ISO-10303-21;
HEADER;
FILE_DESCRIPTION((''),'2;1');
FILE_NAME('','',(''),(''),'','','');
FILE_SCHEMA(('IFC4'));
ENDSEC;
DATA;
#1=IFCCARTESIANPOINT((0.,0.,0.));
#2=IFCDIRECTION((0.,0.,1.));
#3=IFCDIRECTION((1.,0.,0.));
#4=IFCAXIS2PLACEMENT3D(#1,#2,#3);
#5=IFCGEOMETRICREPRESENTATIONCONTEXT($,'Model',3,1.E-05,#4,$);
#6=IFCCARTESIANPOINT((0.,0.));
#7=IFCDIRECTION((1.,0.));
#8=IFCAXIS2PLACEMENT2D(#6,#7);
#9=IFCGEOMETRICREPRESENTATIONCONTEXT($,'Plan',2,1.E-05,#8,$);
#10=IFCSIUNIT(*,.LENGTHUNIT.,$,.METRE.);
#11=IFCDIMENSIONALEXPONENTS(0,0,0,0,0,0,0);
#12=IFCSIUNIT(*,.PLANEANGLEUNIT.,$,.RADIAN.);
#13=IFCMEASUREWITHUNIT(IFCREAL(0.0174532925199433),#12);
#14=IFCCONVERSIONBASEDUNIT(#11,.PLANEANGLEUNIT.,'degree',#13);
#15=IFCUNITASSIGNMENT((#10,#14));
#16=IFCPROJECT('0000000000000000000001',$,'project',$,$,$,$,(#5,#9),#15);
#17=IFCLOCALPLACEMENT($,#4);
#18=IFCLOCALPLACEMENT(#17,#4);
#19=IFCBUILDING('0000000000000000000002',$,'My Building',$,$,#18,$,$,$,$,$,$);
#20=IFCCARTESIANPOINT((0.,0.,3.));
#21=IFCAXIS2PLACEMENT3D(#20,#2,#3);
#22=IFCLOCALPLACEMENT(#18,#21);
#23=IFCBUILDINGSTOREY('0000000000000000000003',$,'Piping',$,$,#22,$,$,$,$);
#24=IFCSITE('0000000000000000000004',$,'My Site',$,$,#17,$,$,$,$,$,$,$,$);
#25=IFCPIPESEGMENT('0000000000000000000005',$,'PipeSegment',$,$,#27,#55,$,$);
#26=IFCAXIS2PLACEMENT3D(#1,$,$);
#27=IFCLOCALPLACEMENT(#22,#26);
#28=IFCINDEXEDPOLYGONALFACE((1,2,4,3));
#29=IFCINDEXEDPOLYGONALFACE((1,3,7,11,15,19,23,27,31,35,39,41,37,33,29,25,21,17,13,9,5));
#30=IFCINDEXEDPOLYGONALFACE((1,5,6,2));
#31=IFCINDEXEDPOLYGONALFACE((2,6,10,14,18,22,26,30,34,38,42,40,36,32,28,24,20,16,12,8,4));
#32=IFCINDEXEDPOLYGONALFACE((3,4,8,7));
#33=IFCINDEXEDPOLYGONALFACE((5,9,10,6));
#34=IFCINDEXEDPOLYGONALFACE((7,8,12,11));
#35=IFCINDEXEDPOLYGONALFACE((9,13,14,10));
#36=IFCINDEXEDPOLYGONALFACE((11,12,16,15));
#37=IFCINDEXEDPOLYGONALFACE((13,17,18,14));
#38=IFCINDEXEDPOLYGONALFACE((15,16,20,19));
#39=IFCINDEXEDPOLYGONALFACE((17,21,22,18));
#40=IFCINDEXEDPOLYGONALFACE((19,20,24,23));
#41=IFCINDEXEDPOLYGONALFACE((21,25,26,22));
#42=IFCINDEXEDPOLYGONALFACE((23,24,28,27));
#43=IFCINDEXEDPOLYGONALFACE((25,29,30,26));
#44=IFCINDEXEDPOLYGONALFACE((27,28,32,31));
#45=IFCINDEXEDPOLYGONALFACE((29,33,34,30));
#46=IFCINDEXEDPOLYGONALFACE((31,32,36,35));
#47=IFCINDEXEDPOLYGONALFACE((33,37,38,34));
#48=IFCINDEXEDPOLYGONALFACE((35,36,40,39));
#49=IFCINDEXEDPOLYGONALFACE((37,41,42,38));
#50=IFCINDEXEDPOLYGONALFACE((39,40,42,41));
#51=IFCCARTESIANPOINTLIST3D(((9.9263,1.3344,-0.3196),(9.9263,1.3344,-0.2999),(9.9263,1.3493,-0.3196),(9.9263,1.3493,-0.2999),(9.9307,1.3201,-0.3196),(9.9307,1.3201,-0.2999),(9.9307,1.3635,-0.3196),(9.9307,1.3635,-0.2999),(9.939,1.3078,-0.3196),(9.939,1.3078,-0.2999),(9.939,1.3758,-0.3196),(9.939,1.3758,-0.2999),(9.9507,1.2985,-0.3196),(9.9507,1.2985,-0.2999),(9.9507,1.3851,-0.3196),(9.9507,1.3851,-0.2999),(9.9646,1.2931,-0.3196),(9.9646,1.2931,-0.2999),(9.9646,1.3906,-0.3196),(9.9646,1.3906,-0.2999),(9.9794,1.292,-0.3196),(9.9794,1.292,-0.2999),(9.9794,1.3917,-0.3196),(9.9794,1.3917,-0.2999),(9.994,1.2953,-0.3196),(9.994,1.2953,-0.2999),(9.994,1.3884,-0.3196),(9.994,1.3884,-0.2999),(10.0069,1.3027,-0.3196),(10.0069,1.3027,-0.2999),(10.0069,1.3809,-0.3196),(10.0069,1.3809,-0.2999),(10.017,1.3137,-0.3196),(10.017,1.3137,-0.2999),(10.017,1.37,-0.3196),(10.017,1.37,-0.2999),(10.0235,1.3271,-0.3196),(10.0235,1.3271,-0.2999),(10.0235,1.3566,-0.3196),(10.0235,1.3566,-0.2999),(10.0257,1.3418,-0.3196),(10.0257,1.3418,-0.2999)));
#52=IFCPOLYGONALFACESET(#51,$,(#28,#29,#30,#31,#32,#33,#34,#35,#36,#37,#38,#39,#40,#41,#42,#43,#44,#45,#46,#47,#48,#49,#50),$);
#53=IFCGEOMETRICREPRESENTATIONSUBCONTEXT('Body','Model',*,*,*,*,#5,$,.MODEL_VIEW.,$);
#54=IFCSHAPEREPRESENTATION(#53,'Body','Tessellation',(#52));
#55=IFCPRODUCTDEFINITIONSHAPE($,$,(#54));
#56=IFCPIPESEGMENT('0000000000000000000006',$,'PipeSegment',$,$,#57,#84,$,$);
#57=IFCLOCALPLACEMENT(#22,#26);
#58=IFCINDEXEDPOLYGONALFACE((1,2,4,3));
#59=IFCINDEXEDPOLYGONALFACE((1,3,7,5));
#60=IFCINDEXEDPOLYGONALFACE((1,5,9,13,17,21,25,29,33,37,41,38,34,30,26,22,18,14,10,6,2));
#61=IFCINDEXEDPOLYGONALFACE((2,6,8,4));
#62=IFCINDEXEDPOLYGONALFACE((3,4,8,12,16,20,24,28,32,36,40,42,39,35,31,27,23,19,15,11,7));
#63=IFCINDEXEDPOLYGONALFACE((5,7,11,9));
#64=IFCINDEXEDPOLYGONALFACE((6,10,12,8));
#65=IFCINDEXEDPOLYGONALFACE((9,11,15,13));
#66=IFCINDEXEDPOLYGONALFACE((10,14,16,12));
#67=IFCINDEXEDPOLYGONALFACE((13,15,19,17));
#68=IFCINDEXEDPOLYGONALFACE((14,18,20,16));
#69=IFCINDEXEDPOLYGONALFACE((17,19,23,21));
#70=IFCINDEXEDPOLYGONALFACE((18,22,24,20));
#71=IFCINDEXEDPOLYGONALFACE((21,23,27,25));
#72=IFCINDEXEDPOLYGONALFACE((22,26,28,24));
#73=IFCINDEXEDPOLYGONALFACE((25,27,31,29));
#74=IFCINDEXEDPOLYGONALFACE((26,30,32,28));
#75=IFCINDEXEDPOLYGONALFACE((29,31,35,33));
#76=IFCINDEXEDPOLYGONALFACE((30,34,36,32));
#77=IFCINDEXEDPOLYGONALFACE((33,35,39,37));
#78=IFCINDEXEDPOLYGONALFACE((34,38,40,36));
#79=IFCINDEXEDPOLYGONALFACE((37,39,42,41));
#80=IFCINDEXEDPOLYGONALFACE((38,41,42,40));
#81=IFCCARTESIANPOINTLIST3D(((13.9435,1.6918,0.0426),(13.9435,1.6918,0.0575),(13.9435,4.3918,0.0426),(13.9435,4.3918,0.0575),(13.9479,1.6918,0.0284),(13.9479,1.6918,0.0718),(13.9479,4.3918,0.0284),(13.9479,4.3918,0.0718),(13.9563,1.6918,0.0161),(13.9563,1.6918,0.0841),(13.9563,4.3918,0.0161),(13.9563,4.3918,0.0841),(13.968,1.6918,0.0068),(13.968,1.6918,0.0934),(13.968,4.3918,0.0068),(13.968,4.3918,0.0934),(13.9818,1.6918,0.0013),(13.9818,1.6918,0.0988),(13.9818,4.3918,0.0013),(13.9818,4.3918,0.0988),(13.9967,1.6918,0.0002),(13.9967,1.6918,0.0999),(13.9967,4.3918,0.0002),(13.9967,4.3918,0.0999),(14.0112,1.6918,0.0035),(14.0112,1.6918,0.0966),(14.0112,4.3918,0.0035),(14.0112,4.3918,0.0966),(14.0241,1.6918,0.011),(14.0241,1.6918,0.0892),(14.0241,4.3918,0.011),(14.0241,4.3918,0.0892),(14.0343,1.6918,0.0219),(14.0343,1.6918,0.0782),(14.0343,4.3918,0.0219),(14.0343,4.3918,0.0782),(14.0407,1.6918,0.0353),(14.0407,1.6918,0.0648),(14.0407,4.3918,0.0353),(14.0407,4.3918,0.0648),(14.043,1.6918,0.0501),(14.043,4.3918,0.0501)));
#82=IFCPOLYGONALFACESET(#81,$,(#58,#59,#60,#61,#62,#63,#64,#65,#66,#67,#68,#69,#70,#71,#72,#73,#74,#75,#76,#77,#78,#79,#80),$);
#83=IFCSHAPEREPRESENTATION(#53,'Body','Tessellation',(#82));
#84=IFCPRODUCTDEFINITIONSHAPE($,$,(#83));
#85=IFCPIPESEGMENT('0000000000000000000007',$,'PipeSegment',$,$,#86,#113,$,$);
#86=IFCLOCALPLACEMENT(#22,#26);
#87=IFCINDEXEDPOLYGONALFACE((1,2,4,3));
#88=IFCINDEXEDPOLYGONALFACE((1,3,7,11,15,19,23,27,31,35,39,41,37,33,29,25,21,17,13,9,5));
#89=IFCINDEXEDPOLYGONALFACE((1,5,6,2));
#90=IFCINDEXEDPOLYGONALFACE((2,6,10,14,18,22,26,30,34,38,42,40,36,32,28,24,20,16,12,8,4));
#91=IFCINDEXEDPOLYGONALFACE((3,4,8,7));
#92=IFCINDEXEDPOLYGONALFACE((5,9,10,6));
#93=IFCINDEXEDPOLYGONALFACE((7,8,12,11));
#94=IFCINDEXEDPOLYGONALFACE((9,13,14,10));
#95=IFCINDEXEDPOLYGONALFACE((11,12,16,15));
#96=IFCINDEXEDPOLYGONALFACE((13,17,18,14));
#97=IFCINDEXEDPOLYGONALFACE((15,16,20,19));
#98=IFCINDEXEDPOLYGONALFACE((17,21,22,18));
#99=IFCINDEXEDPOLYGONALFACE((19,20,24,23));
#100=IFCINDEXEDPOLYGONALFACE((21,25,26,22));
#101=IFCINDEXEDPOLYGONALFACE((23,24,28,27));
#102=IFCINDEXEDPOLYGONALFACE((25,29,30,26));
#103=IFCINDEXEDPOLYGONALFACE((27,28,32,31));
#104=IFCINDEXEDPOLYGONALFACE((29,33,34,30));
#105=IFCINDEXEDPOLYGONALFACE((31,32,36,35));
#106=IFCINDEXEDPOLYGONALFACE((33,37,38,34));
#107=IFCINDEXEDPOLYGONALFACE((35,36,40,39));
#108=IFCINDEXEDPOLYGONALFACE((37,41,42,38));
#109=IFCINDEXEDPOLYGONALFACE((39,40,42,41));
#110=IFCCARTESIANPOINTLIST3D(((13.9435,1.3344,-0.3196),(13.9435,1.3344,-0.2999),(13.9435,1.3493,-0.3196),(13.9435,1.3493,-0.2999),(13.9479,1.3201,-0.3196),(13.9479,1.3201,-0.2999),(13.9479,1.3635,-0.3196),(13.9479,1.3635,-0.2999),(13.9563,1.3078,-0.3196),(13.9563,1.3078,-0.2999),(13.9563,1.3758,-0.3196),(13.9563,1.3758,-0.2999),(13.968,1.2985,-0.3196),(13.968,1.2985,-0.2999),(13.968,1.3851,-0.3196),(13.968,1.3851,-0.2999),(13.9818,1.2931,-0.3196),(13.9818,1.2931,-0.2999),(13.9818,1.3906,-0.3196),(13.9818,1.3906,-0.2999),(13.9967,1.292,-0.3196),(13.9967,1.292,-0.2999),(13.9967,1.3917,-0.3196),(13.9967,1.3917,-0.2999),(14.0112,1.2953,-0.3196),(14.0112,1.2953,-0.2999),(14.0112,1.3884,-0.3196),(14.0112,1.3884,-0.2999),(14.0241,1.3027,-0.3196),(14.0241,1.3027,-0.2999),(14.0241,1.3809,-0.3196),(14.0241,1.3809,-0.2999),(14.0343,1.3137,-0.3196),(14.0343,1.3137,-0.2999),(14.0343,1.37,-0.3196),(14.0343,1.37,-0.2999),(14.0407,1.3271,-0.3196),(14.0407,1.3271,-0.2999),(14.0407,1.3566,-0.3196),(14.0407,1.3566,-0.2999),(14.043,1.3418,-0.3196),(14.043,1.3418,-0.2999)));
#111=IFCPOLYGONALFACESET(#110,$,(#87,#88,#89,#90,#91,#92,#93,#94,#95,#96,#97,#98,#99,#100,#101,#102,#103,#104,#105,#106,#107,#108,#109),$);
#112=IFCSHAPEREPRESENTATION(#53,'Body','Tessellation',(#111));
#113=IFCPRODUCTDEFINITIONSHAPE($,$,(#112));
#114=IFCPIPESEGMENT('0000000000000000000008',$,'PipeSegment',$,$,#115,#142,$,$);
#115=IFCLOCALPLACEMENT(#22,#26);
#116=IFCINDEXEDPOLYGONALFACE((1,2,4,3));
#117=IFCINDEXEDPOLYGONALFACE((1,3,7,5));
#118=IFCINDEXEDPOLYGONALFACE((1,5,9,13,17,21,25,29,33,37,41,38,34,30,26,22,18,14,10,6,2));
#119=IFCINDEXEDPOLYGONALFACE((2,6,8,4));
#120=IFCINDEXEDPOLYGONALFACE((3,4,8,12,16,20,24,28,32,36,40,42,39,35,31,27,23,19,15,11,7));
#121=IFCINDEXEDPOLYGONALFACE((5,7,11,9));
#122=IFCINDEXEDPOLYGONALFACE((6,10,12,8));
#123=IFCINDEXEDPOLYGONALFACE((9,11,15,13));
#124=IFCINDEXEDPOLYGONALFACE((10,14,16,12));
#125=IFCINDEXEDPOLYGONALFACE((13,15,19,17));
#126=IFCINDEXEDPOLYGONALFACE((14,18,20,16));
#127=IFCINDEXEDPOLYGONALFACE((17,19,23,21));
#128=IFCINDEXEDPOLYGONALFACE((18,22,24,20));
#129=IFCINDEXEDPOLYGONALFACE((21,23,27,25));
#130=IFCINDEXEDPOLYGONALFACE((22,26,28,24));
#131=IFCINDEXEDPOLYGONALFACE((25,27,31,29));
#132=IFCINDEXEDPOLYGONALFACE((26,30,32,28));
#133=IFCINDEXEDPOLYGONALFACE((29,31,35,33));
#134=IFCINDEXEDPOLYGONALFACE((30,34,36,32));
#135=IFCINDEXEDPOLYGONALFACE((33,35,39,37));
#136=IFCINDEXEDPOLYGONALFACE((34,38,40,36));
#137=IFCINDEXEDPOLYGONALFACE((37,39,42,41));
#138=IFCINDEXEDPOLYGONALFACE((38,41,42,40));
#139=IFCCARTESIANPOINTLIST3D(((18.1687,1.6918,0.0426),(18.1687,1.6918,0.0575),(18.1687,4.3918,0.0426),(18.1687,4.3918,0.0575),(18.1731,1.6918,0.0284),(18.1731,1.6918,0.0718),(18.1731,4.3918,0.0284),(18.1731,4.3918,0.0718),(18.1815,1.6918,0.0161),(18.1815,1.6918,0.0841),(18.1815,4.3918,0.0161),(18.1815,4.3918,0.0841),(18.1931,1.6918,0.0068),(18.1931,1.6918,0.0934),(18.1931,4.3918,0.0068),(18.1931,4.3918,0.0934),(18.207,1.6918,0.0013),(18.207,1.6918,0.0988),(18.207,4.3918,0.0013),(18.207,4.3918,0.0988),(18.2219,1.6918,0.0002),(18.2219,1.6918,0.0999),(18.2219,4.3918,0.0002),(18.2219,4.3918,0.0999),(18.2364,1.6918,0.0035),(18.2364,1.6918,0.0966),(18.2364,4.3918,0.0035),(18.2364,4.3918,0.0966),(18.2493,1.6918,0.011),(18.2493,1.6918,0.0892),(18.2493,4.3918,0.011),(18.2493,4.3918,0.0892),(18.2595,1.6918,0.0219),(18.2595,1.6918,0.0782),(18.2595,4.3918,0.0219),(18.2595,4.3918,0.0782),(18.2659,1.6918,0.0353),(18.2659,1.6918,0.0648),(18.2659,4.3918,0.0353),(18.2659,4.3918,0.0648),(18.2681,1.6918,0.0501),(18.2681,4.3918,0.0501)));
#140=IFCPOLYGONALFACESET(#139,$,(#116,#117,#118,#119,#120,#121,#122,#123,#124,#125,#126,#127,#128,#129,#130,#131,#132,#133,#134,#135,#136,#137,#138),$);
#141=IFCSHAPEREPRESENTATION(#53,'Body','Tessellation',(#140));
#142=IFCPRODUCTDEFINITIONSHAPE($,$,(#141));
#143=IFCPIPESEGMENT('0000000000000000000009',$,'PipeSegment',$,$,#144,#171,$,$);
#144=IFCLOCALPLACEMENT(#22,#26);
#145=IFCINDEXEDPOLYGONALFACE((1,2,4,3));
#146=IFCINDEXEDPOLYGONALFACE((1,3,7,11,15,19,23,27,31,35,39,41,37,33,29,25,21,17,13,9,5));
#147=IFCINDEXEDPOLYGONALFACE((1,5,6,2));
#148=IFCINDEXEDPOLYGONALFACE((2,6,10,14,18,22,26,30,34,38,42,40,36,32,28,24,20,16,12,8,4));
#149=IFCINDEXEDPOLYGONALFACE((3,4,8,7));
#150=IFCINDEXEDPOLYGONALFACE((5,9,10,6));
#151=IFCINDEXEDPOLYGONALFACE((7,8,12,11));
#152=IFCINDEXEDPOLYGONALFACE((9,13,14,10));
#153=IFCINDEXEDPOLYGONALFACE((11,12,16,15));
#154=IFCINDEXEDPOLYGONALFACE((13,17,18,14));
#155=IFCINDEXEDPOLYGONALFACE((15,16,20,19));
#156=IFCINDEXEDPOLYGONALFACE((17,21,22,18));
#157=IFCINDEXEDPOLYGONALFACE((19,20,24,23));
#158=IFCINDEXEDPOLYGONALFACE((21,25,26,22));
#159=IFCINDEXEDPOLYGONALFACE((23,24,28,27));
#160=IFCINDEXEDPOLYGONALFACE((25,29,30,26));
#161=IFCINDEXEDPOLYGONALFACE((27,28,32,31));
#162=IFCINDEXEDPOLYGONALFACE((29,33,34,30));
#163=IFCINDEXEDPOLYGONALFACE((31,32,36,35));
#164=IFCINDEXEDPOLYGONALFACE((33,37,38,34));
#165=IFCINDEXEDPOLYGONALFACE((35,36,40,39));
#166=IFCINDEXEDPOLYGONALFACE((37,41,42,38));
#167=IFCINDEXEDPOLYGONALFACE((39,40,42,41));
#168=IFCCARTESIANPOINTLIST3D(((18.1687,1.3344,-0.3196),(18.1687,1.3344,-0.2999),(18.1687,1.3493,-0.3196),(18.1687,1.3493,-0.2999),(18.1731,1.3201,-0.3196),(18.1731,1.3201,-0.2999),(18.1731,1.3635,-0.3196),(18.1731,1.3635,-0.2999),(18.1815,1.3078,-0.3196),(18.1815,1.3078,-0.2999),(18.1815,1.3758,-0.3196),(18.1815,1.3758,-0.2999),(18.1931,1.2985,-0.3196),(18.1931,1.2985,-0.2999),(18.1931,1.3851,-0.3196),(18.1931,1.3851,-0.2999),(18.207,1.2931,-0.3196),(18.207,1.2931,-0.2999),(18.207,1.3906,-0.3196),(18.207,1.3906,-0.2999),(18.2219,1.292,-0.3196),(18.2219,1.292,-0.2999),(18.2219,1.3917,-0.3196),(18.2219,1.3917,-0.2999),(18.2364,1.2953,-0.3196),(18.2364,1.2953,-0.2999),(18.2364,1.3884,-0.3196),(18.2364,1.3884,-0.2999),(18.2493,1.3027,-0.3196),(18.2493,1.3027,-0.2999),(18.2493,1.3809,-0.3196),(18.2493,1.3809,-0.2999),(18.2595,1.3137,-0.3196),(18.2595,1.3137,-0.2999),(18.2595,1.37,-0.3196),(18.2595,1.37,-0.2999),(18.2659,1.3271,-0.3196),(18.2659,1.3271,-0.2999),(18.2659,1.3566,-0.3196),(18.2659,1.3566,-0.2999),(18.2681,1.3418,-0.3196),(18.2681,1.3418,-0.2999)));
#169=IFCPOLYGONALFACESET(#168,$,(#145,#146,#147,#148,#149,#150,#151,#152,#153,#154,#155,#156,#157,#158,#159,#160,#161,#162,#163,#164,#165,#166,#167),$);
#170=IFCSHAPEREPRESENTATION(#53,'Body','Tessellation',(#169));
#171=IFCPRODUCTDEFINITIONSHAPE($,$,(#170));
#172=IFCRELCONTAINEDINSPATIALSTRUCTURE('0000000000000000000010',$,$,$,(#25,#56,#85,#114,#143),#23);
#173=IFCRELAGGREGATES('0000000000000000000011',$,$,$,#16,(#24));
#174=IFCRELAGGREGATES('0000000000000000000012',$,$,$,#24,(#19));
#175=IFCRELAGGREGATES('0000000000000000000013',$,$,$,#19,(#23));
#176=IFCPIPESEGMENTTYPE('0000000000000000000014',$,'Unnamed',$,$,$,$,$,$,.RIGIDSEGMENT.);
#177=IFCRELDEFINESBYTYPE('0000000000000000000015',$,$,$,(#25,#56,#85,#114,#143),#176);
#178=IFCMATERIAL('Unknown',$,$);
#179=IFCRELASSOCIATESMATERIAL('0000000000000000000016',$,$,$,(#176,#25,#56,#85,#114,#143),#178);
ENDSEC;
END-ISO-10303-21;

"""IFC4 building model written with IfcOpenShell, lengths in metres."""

from ifc_helpers import new_model, entity, si_unit, converted_unit, frame, origin_with_axes, origin_2d_with_axis, place, context, subcontext, project, spatial, circle, extrude, material, material_profile, profile_set, profile_usage, type_object, element, save


model = new_model("IFC4")

# Units and contexts
model_context = context("Model", 3, precision=1e-05, world=origin_with_axes())
plan_context = context("Plan", 2, precision=1e-05, world=origin_2d_with_axis())
body_context = subcontext(model_context, "Body", "Model", "MODEL_VIEW")
ifc_project = project(units=[si_unit("LENGTHUNIT", "METRE"), converted_unit("PLANEANGLEUNIT", "degree", entity("IfcReal", 0.0174532925199433), si_unit("PLANEANGLEUNIT", "RADIAN"), dimensions=[0, 0, 0, 0, 0, 0, 0])], contexts=[model_context, plan_context])

# Site, building, storey
site_placement = place(None, origin_with_axes())
site = spatial("IfcSite", under=ifc_project, at=site_placement, Name="My Site")
building_placement = place(site_placement, origin_with_axes())
building = spatial("IfcBuilding", under=site, at=building_placement, Name="My Building")
storey_placement = place(building_placement, frame((0.0, 0.0, 3.0), z_axis=(0.0, 0.0, 1.0), x_axis=(1.0, 0.0, 0.0)))
storey = spatial("IfcBuildingStorey", under=building, at=storey_placement, Name="Piping")

# Pipe segments
ifc_material = material(Name="Unknown")
ifc_material_profile_1 = material_profile(ifc_material, circle(Radius=0.05))
ifc_profile_set_1 = profile_set([ifc_material_profile_1])
pipe_segment_type = type_object("IfcPipeSegmentType", Name="Unnamed", PredefinedType="RIGIDSEGMENT", material=ifc_profile_set_1)
ifc_profile_usage_1 = profile_usage(ifc_profile_set_1, cardinal=15)
pipe_segment_1_placement = place(storey_placement, frame((9.9757, 1.3418, -0.2999), z_axis=(0.0, 0.0, -1.0), x_axis=(1.0, 0.0, 0.0)))
element("IfcPipeSegment", 1, at=pipe_segment_1_placement, inside=storey, type_object=pipe_segment_type, material=ifc_profile_usage_1, Name="PipeSegment", context=body_context, shape_type="SweptSolid", body=[
    extrude(circle(Radius=0.05), origin_with_axes(), (0.0, 0.0, 1.0), 0.0196),
])
ifc_profile_usage_2 = profile_usage(ifc_profile_set_1, cardinal=5)
pipe_segment_2_placement = place(storey_placement, frame((13.993, 4.3918, 0.0501), z_axis=(0.0, -1.0, 0.0), x_axis=(1.0, 0.0, 0.0)))
element("IfcPipeSegment", 2, at=pipe_segment_2_placement, inside=storey, type_object=pipe_segment_type, material=ifc_profile_usage_2, Name="PipeSegment", context=body_context, shape_type="SweptSolid", body=[
    extrude(circle(Radius=0.05), origin_with_axes(), (0.0, 0.0, 1.0), 2.7),
])
ifc_profile_usage_3 = profile_usage(ifc_profile_set_1, cardinal=15)
pipe_segment_3_placement = place(storey_placement, frame((13.993, 1.3418, -0.2999), z_axis=(0.0, 0.0, -1.0), x_axis=(1.0, 0.0, 0.0)))
element("IfcPipeSegment", 3, at=pipe_segment_3_placement, inside=storey, type_object=pipe_segment_type, material=ifc_profile_usage_3, Name="PipeSegment", context=body_context, shape_type="SweptSolid", body=[
    extrude(circle(Radius=0.05), origin_with_axes(), (0.0, 0.0, 1.0), 0.0196),
])
ifc_profile_usage_4 = profile_usage(ifc_profile_set_1, cardinal=5)
pipe_segment_4_placement = place(storey_placement, frame((18.2181, 4.3918, 0.0501), z_axis=(0.0, -1.0, 0.0), x_axis=(1.0, 0.0, 0.0)))
element("IfcPipeSegment", 4, at=pipe_segment_4_placement, inside=storey, type_object=pipe_segment_type, material=ifc_profile_usage_4, Name="PipeSegment", context=body_context, shape_type="SweptSolid", body=[
    extrude(circle(Radius=0.05), origin_with_axes(), (0.0, 0.0, 1.0), 2.7),
])
ifc_profile_usage_5 = profile_usage(ifc_profile_set_1, cardinal=15)
pipe_segment_5_placement = place(storey_placement, frame((18.2181, 1.3418, -0.2999), z_axis=(0.0, 0.0, -1.0), x_axis=(1.0, 0.0, 0.0)))
element("IfcPipeSegment", 5, at=pipe_segment_5_placement, inside=storey, type_object=pipe_segment_type, material=ifc_profile_usage_5, Name="PipeSegment", context=body_context, shape_type="SweptSolid", body=[
    extrude(circle(Radius=0.05), origin_with_axes(), (0.0, 0.0, 1.0), 0.0196),
])

save(model, "model.ifc")
